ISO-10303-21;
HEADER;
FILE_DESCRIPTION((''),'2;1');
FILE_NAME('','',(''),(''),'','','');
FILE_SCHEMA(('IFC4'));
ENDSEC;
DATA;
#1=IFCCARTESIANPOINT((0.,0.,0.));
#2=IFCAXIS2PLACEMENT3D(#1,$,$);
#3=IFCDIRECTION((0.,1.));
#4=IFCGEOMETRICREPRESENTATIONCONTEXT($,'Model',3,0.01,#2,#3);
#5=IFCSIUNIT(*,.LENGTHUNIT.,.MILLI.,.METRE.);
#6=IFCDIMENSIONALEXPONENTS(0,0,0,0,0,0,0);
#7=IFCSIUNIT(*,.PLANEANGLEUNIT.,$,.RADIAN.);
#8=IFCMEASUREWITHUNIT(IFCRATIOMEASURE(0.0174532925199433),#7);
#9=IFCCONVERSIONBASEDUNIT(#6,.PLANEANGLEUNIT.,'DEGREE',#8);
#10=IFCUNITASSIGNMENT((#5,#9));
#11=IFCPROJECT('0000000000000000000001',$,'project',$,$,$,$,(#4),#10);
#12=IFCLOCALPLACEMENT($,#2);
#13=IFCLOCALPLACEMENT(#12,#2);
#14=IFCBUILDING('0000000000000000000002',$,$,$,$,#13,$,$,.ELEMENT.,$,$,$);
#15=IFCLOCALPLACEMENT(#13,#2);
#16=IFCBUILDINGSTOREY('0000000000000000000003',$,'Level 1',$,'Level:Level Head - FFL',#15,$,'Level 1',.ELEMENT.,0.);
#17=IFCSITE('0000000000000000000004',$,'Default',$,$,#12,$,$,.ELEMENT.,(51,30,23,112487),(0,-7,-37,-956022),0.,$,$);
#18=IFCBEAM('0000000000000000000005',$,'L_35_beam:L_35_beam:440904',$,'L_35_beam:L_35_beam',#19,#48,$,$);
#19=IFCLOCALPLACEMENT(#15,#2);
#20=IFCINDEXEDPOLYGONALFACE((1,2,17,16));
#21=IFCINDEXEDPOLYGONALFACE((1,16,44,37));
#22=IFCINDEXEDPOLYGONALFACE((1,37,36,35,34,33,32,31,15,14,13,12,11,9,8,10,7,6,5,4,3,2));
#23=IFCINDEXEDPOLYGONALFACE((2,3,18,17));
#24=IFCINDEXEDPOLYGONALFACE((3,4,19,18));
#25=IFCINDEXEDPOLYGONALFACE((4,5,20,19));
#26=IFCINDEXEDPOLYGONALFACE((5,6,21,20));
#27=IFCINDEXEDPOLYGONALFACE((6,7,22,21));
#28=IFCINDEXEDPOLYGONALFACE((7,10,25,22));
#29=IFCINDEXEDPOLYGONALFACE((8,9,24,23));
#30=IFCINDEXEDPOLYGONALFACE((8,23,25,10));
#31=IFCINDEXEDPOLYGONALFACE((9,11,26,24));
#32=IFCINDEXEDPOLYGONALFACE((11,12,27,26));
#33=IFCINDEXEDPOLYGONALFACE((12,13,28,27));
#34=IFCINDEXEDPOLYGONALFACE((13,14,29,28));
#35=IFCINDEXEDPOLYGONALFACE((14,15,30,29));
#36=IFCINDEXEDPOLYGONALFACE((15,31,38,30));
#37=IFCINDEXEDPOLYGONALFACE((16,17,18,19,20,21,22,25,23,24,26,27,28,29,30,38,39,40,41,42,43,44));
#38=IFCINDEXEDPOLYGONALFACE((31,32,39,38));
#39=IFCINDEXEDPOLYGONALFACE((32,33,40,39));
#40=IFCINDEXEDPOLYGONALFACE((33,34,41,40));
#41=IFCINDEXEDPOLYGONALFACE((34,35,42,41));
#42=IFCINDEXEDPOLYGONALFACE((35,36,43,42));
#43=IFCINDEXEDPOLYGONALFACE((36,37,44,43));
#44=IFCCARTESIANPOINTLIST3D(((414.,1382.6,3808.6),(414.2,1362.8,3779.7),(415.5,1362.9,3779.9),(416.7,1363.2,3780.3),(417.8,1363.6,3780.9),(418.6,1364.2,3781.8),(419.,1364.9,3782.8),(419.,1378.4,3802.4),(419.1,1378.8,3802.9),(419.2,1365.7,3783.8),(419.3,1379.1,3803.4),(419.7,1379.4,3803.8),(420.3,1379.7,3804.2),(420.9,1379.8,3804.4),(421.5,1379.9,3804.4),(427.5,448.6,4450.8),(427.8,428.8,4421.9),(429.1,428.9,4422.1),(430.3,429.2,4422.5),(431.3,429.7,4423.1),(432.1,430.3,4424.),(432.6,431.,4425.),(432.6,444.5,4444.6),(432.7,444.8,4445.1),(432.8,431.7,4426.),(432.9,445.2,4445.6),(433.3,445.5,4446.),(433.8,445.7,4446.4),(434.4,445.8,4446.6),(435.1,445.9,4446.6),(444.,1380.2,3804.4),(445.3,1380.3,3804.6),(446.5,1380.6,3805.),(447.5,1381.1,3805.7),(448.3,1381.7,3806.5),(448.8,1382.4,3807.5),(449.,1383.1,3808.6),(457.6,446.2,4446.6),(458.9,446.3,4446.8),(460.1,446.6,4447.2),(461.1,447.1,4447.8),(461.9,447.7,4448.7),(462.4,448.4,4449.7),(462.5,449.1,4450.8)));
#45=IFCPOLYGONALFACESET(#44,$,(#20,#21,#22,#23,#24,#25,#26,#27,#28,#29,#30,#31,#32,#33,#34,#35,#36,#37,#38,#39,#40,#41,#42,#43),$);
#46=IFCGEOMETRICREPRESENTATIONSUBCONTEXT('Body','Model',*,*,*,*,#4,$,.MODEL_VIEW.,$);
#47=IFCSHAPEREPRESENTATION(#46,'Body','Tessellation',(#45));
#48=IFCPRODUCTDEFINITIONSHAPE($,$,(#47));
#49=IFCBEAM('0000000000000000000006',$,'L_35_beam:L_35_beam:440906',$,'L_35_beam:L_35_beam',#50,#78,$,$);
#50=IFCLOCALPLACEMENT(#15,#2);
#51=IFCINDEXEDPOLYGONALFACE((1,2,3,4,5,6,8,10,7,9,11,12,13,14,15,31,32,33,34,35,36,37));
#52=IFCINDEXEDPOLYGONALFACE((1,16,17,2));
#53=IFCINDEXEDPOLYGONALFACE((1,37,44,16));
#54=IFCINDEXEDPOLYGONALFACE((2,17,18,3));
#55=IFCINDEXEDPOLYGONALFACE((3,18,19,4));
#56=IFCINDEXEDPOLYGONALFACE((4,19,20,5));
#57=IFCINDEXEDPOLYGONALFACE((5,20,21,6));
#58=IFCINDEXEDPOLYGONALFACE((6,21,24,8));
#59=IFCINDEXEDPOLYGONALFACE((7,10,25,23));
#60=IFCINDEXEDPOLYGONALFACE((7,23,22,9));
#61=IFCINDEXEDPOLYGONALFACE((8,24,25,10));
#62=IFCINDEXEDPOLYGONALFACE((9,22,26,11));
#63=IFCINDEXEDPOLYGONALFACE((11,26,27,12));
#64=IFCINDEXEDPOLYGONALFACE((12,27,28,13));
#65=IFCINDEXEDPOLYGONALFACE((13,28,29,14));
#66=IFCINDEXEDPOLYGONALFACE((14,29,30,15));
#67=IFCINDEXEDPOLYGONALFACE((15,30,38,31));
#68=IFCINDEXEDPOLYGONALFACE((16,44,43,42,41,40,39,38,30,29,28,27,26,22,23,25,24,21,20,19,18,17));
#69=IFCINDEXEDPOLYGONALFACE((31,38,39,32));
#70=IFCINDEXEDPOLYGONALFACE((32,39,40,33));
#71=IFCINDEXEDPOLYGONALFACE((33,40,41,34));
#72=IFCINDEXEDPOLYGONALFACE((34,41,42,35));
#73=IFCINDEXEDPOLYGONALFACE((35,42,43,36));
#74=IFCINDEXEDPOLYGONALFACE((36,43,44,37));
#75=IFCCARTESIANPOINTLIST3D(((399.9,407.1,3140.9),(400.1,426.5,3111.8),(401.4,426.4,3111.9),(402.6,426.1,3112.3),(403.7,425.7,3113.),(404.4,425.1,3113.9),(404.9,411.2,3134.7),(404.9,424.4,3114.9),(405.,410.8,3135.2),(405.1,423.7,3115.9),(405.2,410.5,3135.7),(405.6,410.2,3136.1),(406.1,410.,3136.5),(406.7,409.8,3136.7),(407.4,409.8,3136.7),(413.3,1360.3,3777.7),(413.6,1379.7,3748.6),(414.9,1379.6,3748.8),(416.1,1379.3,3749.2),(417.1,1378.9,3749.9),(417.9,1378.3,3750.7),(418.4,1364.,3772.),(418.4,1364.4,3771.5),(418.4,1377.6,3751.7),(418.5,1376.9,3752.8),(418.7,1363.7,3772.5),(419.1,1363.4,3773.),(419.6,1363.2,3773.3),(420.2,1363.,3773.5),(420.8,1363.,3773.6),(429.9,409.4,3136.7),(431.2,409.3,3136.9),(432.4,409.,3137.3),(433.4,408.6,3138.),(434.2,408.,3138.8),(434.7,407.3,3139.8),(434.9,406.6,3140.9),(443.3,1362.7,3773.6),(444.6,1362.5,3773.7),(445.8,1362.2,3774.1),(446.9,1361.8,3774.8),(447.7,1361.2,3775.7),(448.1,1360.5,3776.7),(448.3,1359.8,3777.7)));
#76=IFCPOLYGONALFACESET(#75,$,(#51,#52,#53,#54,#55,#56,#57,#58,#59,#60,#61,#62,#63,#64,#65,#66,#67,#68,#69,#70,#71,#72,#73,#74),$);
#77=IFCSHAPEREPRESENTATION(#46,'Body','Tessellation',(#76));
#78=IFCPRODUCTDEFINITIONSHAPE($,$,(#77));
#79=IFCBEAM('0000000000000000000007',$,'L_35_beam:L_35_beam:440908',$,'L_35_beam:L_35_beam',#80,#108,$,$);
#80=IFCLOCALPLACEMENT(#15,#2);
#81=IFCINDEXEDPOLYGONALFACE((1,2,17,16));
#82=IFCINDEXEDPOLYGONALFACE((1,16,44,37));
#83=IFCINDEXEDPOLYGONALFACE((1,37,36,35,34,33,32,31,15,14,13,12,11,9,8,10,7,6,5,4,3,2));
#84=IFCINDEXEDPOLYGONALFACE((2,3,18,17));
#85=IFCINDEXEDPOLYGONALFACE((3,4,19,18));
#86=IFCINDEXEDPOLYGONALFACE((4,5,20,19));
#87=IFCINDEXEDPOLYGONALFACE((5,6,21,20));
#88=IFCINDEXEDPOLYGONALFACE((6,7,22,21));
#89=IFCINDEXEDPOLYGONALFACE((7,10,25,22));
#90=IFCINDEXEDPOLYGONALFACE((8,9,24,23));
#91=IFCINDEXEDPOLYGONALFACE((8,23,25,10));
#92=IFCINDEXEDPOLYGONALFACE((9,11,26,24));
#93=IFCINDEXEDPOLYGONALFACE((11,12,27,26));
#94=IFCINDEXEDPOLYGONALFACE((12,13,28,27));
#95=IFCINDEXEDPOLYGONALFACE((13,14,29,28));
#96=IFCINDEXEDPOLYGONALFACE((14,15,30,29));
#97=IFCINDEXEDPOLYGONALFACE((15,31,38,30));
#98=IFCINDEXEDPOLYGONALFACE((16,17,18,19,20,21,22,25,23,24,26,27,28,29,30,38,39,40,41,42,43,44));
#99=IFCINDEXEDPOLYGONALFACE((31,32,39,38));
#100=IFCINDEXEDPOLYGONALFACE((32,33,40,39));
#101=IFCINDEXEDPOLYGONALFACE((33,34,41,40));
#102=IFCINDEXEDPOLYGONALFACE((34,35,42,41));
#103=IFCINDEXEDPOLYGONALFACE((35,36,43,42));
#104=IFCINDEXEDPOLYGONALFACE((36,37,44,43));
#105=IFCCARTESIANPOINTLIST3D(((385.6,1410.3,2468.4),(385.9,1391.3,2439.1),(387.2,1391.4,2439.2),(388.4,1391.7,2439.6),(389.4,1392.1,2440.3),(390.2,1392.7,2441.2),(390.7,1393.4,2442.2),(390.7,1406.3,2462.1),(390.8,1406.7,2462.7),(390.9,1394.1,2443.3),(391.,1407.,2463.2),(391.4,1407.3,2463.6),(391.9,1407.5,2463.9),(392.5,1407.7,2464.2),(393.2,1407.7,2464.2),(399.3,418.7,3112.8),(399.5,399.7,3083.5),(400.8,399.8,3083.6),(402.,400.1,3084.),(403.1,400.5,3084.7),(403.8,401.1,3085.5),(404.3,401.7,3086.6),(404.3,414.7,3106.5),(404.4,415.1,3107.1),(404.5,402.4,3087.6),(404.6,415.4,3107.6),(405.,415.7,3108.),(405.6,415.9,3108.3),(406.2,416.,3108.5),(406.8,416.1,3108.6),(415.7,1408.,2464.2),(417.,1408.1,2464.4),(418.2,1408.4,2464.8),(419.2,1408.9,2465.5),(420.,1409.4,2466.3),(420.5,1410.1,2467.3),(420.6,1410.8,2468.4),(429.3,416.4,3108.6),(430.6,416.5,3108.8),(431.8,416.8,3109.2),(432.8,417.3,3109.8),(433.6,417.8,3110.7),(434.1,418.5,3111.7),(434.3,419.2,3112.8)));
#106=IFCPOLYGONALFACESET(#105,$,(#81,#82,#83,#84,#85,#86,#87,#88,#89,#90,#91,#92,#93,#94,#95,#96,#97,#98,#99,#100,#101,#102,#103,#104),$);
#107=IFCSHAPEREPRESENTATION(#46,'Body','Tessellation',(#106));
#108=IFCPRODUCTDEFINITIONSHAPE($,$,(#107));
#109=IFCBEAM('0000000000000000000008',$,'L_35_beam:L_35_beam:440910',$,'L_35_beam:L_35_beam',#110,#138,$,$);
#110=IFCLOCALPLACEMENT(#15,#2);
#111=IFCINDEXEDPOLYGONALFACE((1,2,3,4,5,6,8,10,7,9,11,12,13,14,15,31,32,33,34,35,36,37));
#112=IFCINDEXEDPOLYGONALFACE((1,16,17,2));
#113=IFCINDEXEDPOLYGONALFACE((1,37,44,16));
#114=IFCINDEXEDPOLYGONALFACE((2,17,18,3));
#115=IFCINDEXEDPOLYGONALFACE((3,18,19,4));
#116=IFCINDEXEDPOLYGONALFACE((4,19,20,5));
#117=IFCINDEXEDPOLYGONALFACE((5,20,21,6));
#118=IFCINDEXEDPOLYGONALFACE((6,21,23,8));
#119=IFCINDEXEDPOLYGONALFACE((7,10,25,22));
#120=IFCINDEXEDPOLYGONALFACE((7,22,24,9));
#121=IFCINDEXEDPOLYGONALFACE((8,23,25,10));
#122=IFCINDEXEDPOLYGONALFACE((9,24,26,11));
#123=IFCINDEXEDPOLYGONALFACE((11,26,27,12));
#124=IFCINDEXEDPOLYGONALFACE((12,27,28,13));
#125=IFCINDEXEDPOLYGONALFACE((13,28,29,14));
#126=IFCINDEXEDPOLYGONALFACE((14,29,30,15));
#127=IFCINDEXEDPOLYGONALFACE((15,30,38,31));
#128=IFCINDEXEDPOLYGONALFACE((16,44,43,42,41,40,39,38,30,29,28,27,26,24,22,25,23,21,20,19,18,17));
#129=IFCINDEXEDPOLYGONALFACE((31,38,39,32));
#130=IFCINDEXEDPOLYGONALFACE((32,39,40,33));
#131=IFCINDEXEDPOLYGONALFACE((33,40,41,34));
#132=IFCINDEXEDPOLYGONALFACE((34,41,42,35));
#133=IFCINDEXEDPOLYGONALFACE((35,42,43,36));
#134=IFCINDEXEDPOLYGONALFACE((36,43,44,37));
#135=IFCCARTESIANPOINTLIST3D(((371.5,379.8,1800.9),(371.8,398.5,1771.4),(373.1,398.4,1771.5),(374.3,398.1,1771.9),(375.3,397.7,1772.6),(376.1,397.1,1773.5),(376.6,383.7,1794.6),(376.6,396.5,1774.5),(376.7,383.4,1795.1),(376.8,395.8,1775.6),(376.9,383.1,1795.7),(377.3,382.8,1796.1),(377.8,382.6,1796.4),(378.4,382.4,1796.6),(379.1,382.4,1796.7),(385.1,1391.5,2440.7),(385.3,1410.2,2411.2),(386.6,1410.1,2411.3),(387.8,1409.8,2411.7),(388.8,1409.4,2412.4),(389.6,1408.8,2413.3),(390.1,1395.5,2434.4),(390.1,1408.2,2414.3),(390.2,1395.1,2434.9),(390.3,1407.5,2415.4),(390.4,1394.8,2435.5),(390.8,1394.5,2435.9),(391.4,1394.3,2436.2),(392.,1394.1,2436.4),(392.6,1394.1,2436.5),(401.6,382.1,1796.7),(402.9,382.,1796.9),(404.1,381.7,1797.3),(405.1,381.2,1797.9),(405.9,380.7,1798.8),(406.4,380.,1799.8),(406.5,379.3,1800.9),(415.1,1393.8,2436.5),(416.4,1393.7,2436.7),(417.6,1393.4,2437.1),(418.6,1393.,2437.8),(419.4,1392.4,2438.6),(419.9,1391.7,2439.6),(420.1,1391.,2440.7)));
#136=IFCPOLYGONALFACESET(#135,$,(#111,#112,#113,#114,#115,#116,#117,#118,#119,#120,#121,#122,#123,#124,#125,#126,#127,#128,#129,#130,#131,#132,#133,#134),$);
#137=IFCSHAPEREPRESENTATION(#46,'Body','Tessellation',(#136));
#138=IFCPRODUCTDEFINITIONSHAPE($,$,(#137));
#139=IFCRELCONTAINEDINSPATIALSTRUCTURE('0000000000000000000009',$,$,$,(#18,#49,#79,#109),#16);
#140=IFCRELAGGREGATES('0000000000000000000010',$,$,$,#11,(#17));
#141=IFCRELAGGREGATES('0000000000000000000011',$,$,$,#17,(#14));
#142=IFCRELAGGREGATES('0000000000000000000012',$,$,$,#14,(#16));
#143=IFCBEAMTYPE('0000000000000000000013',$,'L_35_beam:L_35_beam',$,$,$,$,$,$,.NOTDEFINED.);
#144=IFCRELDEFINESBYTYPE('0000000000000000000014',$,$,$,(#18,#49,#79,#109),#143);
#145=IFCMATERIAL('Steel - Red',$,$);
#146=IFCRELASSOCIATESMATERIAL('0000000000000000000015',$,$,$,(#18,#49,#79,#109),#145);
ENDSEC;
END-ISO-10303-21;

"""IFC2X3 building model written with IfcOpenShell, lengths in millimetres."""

from ifc_helpers import new_model, entity, si_unit, converted_unit, direction, frame, frame_2d, origin, place, context, subcontext, project, spatial, polyline, circle_curve, parameter, trimmed, segment, composite_curve, outline, extrude, material, type_object, element, save


model = new_model("IFC2X3")

# Units and contexts
model_context = context("Model", 3, precision=0.01, world=origin(), true_north=direction((0.0, 1.0)))
body_context = subcontext(model_context, "Body", "Model", "MODEL_VIEW")
ifc_project = project(units=[si_unit("LENGTHUNIT", "METRE", prefix="MILLI"), converted_unit("PLANEANGLEUNIT", "DEGREE", entity("IfcRatioMeasure", 0.0174532925199433), si_unit("PLANEANGLEUNIT", "RADIAN"), dimensions=[0, 0, 0, 0, 0, 0, 0])], contexts=[model_context])

# Site, building, storey
site_placement = place(None, origin())
site = spatial("IfcSite", under=ifc_project, at=site_placement, Name="Default", CompositionType="ELEMENT", RefLatitude=(51, 30, 23, 112487), RefLongitude=(0, -7, -37, -956022), RefElevation=0.0)
building_placement = place(site_placement, origin())
building = spatial("IfcBuilding", under=site, at=building_placement, CompositionType="ELEMENT")
storey_placement = place(building_placement, origin())
storey = spatial("IfcBuildingStorey", under=building, at=storey_placement, Name="Level 1", ObjectType="Level:Level Head - FFL", LongName="Level 1", CompositionType="ELEMENT", Elevation=0.0)

# Beams
ifc_material_1 = material(Name="Steel - Red")
beam_type = type_object("IfcBeamType", Name="L_35_beam:L_35_beam", PredefinedType="NOTDEFINED")
beam_1_placement = place(storey_placement, frame((419.9, 420.0, 4449.2), z_axis=(-0.00823, 0.566484, 0.824031), x_axis=(-0.01197, 0.823944, -0.566544)))
element("IfcBeam", 1, at=beam_1_placement, inside=storey, type_object=beam_type, material=ifc_material_1, Name="L_35_beam:L_35_beam:440904", ObjectType="L_35_beam:L_35_beam", context=body_context, shape_type="SweptSolid", body=[
    extrude(outline(composite_curve([segment(polyline([(-23.2, -11.8), (11.8, -11.8)]), True, "CONTINUOUS"), segment(polyline([(11.8, -11.8), (11.8, 23.2)]), True, "CONTINUOUS"), segment(trimmed(circle_curve(frame_2d((11.8, 18.2), x_axis=(0.0, 1.0)), 5.0), [parameter(0.0)], [parameter(90.0)], True, "PARAMETER"), True, "CONTINUOUS"), segment(polyline([(6.8, 18.2), (6.8, -4.3)]), True, "CONTINUOUS"), segment(trimmed(circle_curve(frame_2d((4.3, -4.3), x_axis=(1.0, 0.0)), 2.5), [parameter(270.0)], [parameter(0.0)], True, "PARAMETER"), False, "CONTINUOUS"), segment(polyline([(4.3, -6.8), (-18.2, -6.8)]), True, "CONTINUOUS"), segment(trimmed(circle_curve(frame_2d((-18.2, -11.8), x_axis=(0.0, 1.0)), 5.0), [parameter(0.0)], [parameter(90.0)], True, "PARAMETER"), True, "CONTINUOUS")], self_intersect=False)), frame((22.6, -19.8, 5.7), z_axis=(1.0, 0.0, 0.0), x_axis=(0.0, 0.0, 1.0)), (0.0, 0.0, 1.0), 1133.5),
])
beam_2_placement = place(storey_placement, frame((391.6, 391.6, 3109.5), z_axis=(-0.007841, -0.555439, 0.83152), x_axis=(0.011738, 0.831438, 0.555494)))
element("IfcBeam", 2, at=beam_2_placement, inside=storey, type_object=beam_type, material=ifc_material_1, Name="L_35_beam:L_35_beam:440906", ObjectType="L_35_beam:L_35_beam", context=body_context, shape_type="SweptSolid", body=[
    extrude(outline(composite_curve([segment(polyline([(-23.2, -11.8), (11.8, -11.8)]), True, "CONTINUOUS"), segment(polyline([(11.8, -11.8), (11.8, 23.2)]), True, "CONTINUOUS"), segment(trimmed(circle_curve(frame_2d((11.8, 18.2), x_axis=(0.0, 1.0)), 5.0), [parameter(0.0)], [parameter(90.0)], True, "PARAMETER"), True, "CONTINUOUS"), segment(polyline([(6.8, 18.2), (6.8, -4.3)]), True, "CONTINUOUS"), segment(trimmed(circle_curve(frame_2d((4.3, -4.3), x_axis=(1.0, 0.0)), 2.5), [parameter(270.0)], [parameter(0.0)], True, "PARAMETER"), False, "CONTINUOUS"), segment(polyline([(4.3, -6.8), (-18.2, -6.8)]), True, "CONTINUOUS"), segment(trimmed(circle_curve(frame_2d((-18.2, -11.8), x_axis=(0.0, 1.0)), 5.0), [parameter(0.0)], [parameter(90.0)], True, "PARAMETER"), True, "CONTINUOUS")], self_intersect=False)), frame((30.4, -19.8, 5.7), z_axis=(1.0, 0.0, 0.0), x_axis=(0.0, 0.0, 1.0)), (0.0, 0.0, 1.0), 1146.5),
])
beam_3_placement = place(storey_placement, frame((391.6, 391.6, 3109.5), z_axis=(-0.00748, 0.544802, 0.838531), x_axis=(-0.011512, 0.838452, -0.544853)))
element("IfcBeam", 3, at=beam_3_placement, inside=storey, type_object=beam_type, material=ifc_material_1, Name="L_35_beam:L_35_beam:440908", ObjectType="L_35_beam:L_35_beam", context=body_context, shape_type="SweptSolid", body=[
    extrude(outline(composite_curve([segment(polyline([(-23.2, -11.8), (11.8, -11.8)]), True, "CONTINUOUS"), segment(polyline([(11.8, -11.8), (11.8, 23.2)]), True, "CONTINUOUS"), segment(trimmed(circle_curve(frame_2d((11.8, 18.2), x_axis=(0.0, 1.0)), 5.0), [parameter(0.0)], [parameter(90.0)], True, "PARAMETER"), True, "CONTINUOUS"), segment(polyline([(6.8, 18.2), (6.8, -4.3)]), True, "CONTINUOUS"), segment(trimmed(circle_curve(frame_2d((4.3, -4.3), x_axis=(1.0, 0.0)), 2.5), [parameter(270.0)], [parameter(0.0)], True, "PARAMETER"), False, "CONTINUOUS"), segment(polyline([(4.3, -6.8), (-18.2, -6.8)]), True, "CONTINUOUS"), segment(trimmed(circle_curve(frame_2d((-18.2, -11.8), x_axis=(0.0, 1.0)), 5.0), [parameter(0.0)], [parameter(90.0)], True, "PARAMETER"), True, "CONTINUOUS")], self_intersect=False)), frame((20.8, -19.8, 5.7), z_axis=(1.0, 0.0, 0.0), x_axis=(0.0, 0.0, 1.0)), (0.0, 0.0, 1.0), 1182.7),
])
beam_4_placement = place(storey_placement, frame((363.3, 363.3, 1769.8), z_axis=(-0.007141, -0.534401, 0.845201), x_axis=(0.011293, 0.845125, 0.534449)))
element("IfcBeam", 4, at=beam_4_placement, inside=storey, type_object=beam_type, material=ifc_material_1, Name="L_35_beam:L_35_beam:440910", ObjectType="L_35_beam:L_35_beam", context=body_context, shape_type="SweptSolid", body=[
    extrude(outline(composite_curve([segment(polyline([(-23.2, -11.8), (11.8, -11.8)]), True, "CONTINUOUS"), segment(polyline([(11.8, -11.8), (11.8, 23.2)]), True, "CONTINUOUS"), segment(trimmed(circle_curve(frame_2d((11.8, 18.2), x_axis=(0.0, 1.0)), 5.0), [parameter(0.0)], [parameter(90.0)], True, "PARAMETER"), True, "CONTINUOUS"), segment(polyline([(6.8, 18.2), (6.8, -4.3)]), True, "CONTINUOUS"), segment(trimmed(circle_curve(frame_2d((4.3, -4.3), x_axis=(1.0, 0.0)), 2.5), [parameter(270.0)], [parameter(0.0)], True, "PARAMETER"), False, "CONTINUOUS"), segment(polyline([(4.3, -6.8), (-18.2, -6.8)]), True, "CONTINUOUS"), segment(trimmed(circle_curve(frame_2d((-18.2, -11.8), x_axis=(0.0, 1.0)), 5.0), [parameter(0.0)], [parameter(90.0)], True, "PARAMETER"), True, "CONTINUOUS")], self_intersect=False)), frame((30.7, -19.8, 5.7), z_axis=(1.0, 0.0, 0.0), x_axis=(0.0, 0.0, 1.0)), (0.0, 0.0, 1.0), 1197.1),
])

save(model, "model.ifc")
